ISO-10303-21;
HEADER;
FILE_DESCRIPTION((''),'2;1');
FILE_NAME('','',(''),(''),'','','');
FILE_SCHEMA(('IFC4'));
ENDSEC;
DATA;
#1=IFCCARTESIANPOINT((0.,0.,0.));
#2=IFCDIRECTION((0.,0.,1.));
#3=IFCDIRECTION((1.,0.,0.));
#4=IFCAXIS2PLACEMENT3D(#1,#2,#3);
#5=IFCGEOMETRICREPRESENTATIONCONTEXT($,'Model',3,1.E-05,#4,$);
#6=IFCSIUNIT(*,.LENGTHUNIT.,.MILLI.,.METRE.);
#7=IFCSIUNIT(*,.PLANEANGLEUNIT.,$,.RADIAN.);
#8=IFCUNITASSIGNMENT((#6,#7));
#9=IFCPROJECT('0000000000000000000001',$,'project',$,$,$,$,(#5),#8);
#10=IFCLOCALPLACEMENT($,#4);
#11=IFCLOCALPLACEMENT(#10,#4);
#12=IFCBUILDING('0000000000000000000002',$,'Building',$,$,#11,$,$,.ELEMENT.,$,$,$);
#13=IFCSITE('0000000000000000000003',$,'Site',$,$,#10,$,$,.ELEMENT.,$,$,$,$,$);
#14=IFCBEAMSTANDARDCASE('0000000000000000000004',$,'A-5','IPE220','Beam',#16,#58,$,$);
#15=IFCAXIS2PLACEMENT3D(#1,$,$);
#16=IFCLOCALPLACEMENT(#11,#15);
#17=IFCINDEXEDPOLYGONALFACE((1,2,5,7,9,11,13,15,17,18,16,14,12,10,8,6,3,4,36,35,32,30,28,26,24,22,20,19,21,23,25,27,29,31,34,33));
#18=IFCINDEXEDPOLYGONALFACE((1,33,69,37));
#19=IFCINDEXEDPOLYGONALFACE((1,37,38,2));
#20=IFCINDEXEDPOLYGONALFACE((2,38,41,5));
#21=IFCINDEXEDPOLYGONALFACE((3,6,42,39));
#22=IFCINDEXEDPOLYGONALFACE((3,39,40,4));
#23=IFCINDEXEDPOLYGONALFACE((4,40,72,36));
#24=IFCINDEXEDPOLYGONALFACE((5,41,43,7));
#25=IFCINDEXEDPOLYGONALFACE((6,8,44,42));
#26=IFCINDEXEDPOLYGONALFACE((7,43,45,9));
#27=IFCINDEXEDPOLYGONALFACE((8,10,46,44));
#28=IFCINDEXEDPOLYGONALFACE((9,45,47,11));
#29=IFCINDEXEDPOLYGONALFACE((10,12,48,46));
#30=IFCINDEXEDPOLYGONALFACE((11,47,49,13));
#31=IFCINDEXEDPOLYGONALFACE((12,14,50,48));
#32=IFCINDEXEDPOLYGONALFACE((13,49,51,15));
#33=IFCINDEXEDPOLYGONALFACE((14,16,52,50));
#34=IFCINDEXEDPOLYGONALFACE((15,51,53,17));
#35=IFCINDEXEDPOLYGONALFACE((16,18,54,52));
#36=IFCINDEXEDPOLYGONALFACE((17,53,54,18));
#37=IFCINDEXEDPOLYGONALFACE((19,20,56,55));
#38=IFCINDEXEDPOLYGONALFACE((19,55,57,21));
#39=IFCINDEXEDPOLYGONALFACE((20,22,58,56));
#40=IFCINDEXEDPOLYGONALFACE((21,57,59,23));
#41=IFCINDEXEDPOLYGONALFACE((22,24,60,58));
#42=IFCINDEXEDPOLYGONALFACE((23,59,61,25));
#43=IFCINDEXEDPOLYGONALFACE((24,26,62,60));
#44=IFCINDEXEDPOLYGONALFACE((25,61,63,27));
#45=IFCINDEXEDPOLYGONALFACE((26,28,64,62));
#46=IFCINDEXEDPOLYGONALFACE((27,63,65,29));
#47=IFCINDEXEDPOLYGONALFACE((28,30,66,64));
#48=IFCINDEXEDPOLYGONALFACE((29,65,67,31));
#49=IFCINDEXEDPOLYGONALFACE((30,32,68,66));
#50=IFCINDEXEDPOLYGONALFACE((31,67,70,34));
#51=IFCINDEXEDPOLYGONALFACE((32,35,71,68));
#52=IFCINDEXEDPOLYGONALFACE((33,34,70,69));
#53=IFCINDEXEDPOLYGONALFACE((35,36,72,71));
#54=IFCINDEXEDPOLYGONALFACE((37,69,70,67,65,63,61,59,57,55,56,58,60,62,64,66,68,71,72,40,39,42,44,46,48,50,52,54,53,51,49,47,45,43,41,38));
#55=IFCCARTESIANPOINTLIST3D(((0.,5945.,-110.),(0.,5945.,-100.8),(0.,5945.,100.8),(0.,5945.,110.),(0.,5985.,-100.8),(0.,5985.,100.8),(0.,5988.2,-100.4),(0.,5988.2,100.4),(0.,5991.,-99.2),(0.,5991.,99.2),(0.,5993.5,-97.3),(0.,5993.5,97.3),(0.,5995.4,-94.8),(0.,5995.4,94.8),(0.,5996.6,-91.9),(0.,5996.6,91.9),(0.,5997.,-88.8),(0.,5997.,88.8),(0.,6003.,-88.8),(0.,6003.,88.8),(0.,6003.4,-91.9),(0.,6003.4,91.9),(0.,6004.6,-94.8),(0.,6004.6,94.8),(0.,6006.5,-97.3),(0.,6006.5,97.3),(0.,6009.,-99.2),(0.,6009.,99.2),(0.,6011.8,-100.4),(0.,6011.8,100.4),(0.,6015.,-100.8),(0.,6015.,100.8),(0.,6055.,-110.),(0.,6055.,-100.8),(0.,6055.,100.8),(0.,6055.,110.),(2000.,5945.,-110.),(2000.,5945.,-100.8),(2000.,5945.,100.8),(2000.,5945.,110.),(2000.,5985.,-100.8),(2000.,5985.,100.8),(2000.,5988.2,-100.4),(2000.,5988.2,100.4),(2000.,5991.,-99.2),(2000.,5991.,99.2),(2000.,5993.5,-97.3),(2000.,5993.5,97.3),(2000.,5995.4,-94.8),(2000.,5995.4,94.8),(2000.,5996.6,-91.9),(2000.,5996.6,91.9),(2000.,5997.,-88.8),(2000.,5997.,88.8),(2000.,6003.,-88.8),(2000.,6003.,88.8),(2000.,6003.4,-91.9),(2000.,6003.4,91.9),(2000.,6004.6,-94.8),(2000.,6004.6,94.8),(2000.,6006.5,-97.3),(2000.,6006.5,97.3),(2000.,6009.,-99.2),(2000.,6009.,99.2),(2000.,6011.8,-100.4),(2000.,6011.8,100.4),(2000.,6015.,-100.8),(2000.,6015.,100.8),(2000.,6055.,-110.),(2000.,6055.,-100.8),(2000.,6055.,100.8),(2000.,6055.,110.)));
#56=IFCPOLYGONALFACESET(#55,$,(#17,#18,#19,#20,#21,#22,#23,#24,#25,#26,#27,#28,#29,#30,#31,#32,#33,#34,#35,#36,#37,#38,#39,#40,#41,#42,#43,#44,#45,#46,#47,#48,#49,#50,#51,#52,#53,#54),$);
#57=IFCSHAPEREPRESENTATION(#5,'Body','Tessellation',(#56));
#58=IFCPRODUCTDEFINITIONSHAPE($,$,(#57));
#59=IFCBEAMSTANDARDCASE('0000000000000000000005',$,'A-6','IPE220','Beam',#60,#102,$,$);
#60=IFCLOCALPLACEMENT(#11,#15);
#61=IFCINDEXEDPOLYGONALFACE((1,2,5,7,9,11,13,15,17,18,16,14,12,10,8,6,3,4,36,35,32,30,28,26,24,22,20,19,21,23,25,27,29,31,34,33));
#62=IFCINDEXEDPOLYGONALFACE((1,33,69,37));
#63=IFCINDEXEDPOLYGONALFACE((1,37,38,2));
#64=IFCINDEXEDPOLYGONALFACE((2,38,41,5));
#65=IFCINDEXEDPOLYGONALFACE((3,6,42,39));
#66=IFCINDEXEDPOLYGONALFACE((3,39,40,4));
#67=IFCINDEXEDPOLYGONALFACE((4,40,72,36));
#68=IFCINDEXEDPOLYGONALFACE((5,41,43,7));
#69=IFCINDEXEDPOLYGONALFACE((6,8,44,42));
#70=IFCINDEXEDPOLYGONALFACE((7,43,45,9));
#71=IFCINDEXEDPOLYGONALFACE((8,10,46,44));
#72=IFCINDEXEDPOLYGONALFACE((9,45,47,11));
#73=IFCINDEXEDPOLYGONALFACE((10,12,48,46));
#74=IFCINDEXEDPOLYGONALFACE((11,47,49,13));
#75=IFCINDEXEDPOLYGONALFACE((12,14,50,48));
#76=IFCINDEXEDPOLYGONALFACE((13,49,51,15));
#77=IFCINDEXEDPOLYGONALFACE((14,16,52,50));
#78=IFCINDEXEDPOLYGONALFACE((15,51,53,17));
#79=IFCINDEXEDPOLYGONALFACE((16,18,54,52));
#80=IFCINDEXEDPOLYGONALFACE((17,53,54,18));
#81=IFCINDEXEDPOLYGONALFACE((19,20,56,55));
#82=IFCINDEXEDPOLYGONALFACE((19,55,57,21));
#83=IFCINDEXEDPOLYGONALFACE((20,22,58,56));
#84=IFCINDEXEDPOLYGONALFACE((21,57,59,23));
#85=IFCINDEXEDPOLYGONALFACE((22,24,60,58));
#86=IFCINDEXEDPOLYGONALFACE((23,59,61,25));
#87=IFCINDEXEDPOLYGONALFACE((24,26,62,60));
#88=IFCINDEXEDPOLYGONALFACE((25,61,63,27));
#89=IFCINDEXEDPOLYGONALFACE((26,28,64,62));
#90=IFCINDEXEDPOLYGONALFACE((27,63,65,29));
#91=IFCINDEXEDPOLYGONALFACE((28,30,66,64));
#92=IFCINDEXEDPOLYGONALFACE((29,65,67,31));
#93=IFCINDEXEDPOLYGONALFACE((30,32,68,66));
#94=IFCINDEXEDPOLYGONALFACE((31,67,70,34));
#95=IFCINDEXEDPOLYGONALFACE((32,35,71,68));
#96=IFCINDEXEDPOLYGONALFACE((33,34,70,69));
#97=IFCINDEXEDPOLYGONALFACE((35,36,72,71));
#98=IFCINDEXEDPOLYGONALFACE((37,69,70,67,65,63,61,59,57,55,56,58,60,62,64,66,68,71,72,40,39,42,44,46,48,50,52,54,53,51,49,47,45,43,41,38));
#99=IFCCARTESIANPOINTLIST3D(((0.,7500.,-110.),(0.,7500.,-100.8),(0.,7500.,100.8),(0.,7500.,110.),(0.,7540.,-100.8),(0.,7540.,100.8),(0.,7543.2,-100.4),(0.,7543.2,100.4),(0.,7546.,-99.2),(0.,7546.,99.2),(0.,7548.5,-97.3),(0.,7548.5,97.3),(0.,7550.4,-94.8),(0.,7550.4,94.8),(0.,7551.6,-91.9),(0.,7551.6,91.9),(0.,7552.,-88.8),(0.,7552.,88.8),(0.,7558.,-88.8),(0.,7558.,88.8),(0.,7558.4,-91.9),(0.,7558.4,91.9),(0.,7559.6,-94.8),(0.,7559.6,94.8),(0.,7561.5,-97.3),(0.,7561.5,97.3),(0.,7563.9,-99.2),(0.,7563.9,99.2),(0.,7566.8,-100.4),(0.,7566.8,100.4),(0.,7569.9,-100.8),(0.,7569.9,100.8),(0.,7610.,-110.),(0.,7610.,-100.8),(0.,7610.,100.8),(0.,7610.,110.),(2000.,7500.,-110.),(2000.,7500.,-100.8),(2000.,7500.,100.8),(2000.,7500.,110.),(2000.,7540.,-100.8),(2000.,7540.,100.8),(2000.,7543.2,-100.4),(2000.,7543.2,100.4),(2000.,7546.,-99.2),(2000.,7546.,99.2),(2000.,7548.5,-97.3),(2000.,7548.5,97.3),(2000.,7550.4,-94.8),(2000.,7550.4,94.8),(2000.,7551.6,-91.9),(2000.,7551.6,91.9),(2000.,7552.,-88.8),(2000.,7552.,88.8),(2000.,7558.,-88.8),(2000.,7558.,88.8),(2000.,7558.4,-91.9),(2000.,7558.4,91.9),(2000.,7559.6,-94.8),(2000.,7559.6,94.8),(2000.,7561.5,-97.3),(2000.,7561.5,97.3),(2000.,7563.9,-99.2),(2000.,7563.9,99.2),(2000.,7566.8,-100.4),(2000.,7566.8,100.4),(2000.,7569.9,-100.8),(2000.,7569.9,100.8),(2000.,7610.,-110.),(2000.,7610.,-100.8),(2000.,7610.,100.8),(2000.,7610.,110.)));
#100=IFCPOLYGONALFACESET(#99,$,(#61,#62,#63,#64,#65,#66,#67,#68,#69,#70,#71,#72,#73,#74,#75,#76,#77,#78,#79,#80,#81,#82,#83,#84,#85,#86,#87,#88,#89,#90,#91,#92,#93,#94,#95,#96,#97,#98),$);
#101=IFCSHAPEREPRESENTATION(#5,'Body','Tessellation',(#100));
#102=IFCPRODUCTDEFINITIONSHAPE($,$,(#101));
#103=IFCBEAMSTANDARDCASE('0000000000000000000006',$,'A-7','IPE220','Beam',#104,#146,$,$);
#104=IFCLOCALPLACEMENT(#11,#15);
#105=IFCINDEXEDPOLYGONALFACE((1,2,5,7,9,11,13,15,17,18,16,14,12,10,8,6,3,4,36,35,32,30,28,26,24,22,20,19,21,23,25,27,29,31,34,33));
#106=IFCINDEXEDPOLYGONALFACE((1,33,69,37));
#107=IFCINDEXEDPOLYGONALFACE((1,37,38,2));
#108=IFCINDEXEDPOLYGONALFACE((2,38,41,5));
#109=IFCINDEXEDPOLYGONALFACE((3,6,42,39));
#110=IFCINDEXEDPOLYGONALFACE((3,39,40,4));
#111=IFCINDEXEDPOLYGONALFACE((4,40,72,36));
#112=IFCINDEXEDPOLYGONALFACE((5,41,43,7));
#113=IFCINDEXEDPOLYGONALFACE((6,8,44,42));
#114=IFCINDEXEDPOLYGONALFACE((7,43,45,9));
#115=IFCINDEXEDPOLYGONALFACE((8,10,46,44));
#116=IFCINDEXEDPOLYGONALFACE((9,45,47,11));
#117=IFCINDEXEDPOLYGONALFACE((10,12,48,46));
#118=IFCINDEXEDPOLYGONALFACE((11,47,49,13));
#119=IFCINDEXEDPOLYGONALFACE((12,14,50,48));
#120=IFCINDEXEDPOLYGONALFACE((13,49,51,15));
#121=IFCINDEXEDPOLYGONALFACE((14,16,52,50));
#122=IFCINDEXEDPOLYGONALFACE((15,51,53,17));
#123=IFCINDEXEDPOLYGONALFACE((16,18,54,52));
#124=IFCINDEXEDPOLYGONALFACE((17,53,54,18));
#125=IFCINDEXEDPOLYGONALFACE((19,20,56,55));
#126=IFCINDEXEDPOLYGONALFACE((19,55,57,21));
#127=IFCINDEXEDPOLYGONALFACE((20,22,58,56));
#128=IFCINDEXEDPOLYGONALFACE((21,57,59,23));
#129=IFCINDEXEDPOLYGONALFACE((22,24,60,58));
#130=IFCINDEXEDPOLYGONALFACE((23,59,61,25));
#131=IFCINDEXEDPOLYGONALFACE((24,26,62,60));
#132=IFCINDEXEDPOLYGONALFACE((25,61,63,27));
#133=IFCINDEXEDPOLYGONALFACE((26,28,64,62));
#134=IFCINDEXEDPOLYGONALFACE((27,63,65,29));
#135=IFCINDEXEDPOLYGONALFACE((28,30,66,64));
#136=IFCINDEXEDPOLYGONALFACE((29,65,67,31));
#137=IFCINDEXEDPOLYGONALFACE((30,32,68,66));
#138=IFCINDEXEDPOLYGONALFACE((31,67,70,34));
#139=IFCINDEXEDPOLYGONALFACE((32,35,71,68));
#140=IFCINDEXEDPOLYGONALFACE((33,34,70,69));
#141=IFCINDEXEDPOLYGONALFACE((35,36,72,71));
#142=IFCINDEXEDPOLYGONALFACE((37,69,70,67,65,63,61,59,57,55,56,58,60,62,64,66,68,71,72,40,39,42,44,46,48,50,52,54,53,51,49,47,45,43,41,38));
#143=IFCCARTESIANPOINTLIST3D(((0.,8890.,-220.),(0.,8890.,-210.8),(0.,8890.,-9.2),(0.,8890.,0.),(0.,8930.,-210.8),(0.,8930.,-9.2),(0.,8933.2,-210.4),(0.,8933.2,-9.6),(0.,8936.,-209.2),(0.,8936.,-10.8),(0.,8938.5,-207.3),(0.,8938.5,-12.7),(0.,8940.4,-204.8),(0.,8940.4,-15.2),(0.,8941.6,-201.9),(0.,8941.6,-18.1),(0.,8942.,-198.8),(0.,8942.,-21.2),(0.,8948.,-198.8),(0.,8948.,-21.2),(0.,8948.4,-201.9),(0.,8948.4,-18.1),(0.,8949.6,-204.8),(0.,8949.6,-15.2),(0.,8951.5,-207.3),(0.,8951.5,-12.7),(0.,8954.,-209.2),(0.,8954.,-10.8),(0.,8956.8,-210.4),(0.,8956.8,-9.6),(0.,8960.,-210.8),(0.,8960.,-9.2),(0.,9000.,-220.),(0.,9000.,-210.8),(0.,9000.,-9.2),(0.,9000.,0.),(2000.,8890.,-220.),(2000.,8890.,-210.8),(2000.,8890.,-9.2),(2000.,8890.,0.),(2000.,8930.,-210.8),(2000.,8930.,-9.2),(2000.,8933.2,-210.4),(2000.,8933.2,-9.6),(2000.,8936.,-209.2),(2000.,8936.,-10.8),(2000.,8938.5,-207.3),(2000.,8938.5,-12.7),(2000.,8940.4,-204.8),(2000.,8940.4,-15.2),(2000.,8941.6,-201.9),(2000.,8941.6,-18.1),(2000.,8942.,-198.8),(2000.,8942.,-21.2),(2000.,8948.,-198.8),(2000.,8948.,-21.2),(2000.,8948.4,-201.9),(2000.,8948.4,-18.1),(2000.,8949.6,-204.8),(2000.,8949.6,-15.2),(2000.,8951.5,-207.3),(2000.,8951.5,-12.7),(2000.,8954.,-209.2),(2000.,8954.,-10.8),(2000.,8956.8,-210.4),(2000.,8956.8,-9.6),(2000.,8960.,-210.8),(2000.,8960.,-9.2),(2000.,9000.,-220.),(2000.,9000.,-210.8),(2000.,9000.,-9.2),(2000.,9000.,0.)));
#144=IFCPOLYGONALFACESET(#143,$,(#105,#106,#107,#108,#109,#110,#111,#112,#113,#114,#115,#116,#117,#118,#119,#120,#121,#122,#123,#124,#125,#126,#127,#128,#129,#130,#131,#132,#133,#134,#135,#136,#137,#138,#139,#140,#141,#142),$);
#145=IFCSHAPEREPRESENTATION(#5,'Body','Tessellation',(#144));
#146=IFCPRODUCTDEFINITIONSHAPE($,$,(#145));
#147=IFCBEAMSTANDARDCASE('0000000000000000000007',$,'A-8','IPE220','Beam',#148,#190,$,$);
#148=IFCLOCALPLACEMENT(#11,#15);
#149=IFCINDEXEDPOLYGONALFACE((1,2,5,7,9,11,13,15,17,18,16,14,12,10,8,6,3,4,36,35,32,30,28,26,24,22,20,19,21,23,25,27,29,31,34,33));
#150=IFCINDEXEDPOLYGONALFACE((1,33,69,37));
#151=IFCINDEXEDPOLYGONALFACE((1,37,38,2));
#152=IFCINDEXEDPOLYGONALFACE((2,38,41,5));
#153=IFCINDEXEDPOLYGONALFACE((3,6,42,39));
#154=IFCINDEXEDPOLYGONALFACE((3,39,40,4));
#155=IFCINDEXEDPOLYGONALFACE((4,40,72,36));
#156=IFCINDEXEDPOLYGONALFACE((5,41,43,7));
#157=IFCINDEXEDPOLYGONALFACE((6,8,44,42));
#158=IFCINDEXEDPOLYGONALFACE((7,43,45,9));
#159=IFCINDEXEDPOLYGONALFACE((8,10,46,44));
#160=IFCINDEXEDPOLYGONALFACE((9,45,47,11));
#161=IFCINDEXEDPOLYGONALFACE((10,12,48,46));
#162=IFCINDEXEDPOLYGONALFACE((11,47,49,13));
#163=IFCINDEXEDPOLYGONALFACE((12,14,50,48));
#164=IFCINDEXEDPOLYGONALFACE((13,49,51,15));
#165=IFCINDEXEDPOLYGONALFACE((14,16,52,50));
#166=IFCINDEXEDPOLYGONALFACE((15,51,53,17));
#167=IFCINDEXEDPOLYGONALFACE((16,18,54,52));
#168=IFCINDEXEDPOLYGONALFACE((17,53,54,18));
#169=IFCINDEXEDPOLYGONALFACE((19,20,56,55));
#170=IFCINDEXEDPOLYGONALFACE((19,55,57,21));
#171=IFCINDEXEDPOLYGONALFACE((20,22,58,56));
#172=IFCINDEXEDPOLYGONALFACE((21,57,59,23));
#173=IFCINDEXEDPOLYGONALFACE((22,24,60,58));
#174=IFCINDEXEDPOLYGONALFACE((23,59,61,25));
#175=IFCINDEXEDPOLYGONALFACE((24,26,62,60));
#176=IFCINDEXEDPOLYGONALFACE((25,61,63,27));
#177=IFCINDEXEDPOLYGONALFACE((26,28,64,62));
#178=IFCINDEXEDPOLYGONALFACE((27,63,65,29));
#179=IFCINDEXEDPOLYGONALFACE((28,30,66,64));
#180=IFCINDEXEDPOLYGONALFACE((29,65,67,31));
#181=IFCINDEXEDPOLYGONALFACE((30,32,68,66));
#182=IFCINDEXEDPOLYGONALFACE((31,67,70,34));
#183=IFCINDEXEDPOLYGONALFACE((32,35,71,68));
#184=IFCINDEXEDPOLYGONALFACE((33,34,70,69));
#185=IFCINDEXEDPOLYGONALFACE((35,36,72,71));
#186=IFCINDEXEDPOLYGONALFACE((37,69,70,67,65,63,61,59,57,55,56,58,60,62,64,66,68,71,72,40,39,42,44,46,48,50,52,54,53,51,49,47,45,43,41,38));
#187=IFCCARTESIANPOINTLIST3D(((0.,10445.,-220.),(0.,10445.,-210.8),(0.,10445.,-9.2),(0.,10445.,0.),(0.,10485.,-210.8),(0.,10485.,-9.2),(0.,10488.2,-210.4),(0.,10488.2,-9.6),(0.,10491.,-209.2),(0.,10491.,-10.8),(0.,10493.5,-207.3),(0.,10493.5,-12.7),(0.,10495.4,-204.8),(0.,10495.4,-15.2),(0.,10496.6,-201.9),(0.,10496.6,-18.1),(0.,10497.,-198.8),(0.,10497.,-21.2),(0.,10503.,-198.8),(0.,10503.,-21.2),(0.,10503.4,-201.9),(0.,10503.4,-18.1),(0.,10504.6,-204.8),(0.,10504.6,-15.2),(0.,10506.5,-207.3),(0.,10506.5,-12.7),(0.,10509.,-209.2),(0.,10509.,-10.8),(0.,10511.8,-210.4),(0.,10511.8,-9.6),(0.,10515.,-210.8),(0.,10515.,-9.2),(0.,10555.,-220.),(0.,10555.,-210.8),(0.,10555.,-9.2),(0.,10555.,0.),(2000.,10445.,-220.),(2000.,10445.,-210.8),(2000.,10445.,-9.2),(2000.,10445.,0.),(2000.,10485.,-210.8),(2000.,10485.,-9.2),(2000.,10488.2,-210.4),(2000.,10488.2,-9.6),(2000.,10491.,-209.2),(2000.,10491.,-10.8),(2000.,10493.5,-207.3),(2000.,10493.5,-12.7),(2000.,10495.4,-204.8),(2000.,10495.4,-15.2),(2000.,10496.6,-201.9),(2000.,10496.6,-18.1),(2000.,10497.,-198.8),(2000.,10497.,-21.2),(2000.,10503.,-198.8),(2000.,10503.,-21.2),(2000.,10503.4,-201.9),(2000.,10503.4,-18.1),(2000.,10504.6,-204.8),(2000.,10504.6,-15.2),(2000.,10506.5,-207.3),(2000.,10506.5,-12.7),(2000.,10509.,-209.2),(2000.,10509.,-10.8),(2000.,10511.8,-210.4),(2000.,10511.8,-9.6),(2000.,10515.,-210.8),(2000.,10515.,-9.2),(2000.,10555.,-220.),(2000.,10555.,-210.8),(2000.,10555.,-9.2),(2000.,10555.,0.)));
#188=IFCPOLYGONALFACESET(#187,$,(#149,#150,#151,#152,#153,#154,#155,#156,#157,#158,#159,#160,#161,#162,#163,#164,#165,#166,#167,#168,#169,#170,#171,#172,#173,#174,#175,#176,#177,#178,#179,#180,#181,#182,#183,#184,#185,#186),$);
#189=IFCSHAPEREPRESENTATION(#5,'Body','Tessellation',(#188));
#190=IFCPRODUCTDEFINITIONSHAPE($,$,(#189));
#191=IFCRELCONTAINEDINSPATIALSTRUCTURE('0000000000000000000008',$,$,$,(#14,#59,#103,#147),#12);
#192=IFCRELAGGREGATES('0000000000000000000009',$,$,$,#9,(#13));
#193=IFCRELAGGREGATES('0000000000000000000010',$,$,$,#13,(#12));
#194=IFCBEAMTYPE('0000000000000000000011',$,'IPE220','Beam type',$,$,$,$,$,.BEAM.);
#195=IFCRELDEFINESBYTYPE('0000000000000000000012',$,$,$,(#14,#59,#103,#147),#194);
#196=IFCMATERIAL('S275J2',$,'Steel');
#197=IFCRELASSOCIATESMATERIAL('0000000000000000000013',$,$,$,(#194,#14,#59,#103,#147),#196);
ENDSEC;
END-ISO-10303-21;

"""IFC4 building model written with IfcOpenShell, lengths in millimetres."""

from ifc_helpers import new_model, si_unit, frame, origin, origin_with_axes, place, context, project, spatial, i_section, extrude, material, material_profile, profile_set, profile_usage, type_object, element, save


model = new_model("IFC4")

# Units and contexts
model_context = context("Model", 3, precision=1e-05, world=origin_with_axes())
ifc_project = project(units=[si_unit("LENGTHUNIT", "METRE", prefix="MILLI"), si_unit("PLANEANGLEUNIT", "RADIAN")], contexts=[model_context])

# Site, building
site_placement = place(None, origin_with_axes())
site = spatial("IfcSite", under=ifc_project, at=site_placement, Name="Site", CompositionType="ELEMENT")
building_placement = place(site_placement, origin_with_axes())
building = spatial("IfcBuilding", under=site, at=building_placement, Name="Building", CompositionType="ELEMENT")

# Beams
ifc_material_1 = material(Name="S275J2", Category="Steel")
ifc_material_profile_1 = material_profile(ifc_material_1, i_section(OverallWidth=110.0, OverallDepth=220.0, WebThickness=5.9, FlangeThickness=9.2, FilletRadius=12.0), Name="IPE220")
ifc_profile_set_1 = profile_set([ifc_material_profile_1])
beam_type_1 = type_object("IfcBeamType", Name="IPE220", Description="Beam type", PredefinedType="BEAM", material=ifc_profile_set_1)
ifc_profile_usage_1 = profile_usage(ifc_profile_set_1, cardinal=5)
beam_1_placement = place(building_placement, frame((0.0, 6000.0, 0.0), z_axis=(1.0, 0.0, 0.0), x_axis=(0.0, 1.0, 0.0)))
element("IfcBeamStandardCase", 1, at=beam_1_placement, inside=building, type_object=beam_type_1, material=ifc_profile_usage_1, Name="A-5", Description="IPE220", ObjectType="Beam", context=model_context, shape_type="SweptSolid", body=[
    extrude(i_section(OverallWidth=110.0, OverallDepth=220.0, WebThickness=5.9, FlangeThickness=9.2, FilletRadius=12.0), origin(), (0.0, 0.0, 1.0), 2000.0),
])
ifc_profile_usage_2 = profile_usage(ifc_profile_set_1, cardinal=6)
beam_2_placement = place(building_placement, frame((0.0, 7500.0, 0.0), z_axis=(1.0, 0.0, 0.0), x_axis=(0.0, 1.0, 0.0)))
element("IfcBeamStandardCase", 2, at=beam_2_placement, inside=building, type_object=beam_type_1, material=ifc_profile_usage_2, Name="A-6", Description="IPE220", ObjectType="Beam", context=model_context, shape_type="SweptSolid", body=[
    extrude(i_section(OverallWidth=110.0, OverallDepth=220.0, WebThickness=5.9, FlangeThickness=9.2, FilletRadius=12.0), frame((55.0, 0.0, 0.0)), (0.0, 0.0, 1.0), 2000.0),
])
ifc_profile_usage_3 = profile_usage(ifc_profile_set_1, cardinal=7)
beam_3_placement = place(building_placement, frame((0.0, 9000.0, 0.0), z_axis=(1.0, 0.0, 0.0), x_axis=(0.0, 1.0, 0.0)))
element("IfcBeamStandardCase", 3, at=beam_3_placement, inside=building, type_object=beam_type_1, material=ifc_profile_usage_3, Name="A-7", Description="IPE220", ObjectType="Beam", context=model_context, shape_type="SweptSolid", body=[
    extrude(i_section(OverallWidth=110.0, OverallDepth=220.0, WebThickness=5.9, FlangeThickness=9.2, FilletRadius=12.0), frame((-55.0, -110.0, 0.0)), (0.0, 0.0, 1.0), 2000.0),
])
ifc_profile_usage_4 = profile_usage(ifc_profile_set_1, cardinal=8)
beam_4_placement = place(building_placement, frame((0.0, 10500.0, 0.0), z_axis=(1.0, 0.0, 0.0), x_axis=(0.0, 1.0, 0.0)))
element("IfcBeamStandardCase", 4, at=beam_4_placement, inside=building, type_object=beam_type_1, material=ifc_profile_usage_4, Name="A-8", Description="IPE220", ObjectType="Beam", context=model_context, shape_type="SweptSolid", body=[
    extrude(i_section(OverallWidth=110.0, OverallDepth=220.0, WebThickness=5.9, FlangeThickness=9.2, FilletRadius=12.0), frame((0.0, -110.0, 0.0)), (0.0, 0.0, 1.0), 2000.0),
])

save(model, "model.ifc")
